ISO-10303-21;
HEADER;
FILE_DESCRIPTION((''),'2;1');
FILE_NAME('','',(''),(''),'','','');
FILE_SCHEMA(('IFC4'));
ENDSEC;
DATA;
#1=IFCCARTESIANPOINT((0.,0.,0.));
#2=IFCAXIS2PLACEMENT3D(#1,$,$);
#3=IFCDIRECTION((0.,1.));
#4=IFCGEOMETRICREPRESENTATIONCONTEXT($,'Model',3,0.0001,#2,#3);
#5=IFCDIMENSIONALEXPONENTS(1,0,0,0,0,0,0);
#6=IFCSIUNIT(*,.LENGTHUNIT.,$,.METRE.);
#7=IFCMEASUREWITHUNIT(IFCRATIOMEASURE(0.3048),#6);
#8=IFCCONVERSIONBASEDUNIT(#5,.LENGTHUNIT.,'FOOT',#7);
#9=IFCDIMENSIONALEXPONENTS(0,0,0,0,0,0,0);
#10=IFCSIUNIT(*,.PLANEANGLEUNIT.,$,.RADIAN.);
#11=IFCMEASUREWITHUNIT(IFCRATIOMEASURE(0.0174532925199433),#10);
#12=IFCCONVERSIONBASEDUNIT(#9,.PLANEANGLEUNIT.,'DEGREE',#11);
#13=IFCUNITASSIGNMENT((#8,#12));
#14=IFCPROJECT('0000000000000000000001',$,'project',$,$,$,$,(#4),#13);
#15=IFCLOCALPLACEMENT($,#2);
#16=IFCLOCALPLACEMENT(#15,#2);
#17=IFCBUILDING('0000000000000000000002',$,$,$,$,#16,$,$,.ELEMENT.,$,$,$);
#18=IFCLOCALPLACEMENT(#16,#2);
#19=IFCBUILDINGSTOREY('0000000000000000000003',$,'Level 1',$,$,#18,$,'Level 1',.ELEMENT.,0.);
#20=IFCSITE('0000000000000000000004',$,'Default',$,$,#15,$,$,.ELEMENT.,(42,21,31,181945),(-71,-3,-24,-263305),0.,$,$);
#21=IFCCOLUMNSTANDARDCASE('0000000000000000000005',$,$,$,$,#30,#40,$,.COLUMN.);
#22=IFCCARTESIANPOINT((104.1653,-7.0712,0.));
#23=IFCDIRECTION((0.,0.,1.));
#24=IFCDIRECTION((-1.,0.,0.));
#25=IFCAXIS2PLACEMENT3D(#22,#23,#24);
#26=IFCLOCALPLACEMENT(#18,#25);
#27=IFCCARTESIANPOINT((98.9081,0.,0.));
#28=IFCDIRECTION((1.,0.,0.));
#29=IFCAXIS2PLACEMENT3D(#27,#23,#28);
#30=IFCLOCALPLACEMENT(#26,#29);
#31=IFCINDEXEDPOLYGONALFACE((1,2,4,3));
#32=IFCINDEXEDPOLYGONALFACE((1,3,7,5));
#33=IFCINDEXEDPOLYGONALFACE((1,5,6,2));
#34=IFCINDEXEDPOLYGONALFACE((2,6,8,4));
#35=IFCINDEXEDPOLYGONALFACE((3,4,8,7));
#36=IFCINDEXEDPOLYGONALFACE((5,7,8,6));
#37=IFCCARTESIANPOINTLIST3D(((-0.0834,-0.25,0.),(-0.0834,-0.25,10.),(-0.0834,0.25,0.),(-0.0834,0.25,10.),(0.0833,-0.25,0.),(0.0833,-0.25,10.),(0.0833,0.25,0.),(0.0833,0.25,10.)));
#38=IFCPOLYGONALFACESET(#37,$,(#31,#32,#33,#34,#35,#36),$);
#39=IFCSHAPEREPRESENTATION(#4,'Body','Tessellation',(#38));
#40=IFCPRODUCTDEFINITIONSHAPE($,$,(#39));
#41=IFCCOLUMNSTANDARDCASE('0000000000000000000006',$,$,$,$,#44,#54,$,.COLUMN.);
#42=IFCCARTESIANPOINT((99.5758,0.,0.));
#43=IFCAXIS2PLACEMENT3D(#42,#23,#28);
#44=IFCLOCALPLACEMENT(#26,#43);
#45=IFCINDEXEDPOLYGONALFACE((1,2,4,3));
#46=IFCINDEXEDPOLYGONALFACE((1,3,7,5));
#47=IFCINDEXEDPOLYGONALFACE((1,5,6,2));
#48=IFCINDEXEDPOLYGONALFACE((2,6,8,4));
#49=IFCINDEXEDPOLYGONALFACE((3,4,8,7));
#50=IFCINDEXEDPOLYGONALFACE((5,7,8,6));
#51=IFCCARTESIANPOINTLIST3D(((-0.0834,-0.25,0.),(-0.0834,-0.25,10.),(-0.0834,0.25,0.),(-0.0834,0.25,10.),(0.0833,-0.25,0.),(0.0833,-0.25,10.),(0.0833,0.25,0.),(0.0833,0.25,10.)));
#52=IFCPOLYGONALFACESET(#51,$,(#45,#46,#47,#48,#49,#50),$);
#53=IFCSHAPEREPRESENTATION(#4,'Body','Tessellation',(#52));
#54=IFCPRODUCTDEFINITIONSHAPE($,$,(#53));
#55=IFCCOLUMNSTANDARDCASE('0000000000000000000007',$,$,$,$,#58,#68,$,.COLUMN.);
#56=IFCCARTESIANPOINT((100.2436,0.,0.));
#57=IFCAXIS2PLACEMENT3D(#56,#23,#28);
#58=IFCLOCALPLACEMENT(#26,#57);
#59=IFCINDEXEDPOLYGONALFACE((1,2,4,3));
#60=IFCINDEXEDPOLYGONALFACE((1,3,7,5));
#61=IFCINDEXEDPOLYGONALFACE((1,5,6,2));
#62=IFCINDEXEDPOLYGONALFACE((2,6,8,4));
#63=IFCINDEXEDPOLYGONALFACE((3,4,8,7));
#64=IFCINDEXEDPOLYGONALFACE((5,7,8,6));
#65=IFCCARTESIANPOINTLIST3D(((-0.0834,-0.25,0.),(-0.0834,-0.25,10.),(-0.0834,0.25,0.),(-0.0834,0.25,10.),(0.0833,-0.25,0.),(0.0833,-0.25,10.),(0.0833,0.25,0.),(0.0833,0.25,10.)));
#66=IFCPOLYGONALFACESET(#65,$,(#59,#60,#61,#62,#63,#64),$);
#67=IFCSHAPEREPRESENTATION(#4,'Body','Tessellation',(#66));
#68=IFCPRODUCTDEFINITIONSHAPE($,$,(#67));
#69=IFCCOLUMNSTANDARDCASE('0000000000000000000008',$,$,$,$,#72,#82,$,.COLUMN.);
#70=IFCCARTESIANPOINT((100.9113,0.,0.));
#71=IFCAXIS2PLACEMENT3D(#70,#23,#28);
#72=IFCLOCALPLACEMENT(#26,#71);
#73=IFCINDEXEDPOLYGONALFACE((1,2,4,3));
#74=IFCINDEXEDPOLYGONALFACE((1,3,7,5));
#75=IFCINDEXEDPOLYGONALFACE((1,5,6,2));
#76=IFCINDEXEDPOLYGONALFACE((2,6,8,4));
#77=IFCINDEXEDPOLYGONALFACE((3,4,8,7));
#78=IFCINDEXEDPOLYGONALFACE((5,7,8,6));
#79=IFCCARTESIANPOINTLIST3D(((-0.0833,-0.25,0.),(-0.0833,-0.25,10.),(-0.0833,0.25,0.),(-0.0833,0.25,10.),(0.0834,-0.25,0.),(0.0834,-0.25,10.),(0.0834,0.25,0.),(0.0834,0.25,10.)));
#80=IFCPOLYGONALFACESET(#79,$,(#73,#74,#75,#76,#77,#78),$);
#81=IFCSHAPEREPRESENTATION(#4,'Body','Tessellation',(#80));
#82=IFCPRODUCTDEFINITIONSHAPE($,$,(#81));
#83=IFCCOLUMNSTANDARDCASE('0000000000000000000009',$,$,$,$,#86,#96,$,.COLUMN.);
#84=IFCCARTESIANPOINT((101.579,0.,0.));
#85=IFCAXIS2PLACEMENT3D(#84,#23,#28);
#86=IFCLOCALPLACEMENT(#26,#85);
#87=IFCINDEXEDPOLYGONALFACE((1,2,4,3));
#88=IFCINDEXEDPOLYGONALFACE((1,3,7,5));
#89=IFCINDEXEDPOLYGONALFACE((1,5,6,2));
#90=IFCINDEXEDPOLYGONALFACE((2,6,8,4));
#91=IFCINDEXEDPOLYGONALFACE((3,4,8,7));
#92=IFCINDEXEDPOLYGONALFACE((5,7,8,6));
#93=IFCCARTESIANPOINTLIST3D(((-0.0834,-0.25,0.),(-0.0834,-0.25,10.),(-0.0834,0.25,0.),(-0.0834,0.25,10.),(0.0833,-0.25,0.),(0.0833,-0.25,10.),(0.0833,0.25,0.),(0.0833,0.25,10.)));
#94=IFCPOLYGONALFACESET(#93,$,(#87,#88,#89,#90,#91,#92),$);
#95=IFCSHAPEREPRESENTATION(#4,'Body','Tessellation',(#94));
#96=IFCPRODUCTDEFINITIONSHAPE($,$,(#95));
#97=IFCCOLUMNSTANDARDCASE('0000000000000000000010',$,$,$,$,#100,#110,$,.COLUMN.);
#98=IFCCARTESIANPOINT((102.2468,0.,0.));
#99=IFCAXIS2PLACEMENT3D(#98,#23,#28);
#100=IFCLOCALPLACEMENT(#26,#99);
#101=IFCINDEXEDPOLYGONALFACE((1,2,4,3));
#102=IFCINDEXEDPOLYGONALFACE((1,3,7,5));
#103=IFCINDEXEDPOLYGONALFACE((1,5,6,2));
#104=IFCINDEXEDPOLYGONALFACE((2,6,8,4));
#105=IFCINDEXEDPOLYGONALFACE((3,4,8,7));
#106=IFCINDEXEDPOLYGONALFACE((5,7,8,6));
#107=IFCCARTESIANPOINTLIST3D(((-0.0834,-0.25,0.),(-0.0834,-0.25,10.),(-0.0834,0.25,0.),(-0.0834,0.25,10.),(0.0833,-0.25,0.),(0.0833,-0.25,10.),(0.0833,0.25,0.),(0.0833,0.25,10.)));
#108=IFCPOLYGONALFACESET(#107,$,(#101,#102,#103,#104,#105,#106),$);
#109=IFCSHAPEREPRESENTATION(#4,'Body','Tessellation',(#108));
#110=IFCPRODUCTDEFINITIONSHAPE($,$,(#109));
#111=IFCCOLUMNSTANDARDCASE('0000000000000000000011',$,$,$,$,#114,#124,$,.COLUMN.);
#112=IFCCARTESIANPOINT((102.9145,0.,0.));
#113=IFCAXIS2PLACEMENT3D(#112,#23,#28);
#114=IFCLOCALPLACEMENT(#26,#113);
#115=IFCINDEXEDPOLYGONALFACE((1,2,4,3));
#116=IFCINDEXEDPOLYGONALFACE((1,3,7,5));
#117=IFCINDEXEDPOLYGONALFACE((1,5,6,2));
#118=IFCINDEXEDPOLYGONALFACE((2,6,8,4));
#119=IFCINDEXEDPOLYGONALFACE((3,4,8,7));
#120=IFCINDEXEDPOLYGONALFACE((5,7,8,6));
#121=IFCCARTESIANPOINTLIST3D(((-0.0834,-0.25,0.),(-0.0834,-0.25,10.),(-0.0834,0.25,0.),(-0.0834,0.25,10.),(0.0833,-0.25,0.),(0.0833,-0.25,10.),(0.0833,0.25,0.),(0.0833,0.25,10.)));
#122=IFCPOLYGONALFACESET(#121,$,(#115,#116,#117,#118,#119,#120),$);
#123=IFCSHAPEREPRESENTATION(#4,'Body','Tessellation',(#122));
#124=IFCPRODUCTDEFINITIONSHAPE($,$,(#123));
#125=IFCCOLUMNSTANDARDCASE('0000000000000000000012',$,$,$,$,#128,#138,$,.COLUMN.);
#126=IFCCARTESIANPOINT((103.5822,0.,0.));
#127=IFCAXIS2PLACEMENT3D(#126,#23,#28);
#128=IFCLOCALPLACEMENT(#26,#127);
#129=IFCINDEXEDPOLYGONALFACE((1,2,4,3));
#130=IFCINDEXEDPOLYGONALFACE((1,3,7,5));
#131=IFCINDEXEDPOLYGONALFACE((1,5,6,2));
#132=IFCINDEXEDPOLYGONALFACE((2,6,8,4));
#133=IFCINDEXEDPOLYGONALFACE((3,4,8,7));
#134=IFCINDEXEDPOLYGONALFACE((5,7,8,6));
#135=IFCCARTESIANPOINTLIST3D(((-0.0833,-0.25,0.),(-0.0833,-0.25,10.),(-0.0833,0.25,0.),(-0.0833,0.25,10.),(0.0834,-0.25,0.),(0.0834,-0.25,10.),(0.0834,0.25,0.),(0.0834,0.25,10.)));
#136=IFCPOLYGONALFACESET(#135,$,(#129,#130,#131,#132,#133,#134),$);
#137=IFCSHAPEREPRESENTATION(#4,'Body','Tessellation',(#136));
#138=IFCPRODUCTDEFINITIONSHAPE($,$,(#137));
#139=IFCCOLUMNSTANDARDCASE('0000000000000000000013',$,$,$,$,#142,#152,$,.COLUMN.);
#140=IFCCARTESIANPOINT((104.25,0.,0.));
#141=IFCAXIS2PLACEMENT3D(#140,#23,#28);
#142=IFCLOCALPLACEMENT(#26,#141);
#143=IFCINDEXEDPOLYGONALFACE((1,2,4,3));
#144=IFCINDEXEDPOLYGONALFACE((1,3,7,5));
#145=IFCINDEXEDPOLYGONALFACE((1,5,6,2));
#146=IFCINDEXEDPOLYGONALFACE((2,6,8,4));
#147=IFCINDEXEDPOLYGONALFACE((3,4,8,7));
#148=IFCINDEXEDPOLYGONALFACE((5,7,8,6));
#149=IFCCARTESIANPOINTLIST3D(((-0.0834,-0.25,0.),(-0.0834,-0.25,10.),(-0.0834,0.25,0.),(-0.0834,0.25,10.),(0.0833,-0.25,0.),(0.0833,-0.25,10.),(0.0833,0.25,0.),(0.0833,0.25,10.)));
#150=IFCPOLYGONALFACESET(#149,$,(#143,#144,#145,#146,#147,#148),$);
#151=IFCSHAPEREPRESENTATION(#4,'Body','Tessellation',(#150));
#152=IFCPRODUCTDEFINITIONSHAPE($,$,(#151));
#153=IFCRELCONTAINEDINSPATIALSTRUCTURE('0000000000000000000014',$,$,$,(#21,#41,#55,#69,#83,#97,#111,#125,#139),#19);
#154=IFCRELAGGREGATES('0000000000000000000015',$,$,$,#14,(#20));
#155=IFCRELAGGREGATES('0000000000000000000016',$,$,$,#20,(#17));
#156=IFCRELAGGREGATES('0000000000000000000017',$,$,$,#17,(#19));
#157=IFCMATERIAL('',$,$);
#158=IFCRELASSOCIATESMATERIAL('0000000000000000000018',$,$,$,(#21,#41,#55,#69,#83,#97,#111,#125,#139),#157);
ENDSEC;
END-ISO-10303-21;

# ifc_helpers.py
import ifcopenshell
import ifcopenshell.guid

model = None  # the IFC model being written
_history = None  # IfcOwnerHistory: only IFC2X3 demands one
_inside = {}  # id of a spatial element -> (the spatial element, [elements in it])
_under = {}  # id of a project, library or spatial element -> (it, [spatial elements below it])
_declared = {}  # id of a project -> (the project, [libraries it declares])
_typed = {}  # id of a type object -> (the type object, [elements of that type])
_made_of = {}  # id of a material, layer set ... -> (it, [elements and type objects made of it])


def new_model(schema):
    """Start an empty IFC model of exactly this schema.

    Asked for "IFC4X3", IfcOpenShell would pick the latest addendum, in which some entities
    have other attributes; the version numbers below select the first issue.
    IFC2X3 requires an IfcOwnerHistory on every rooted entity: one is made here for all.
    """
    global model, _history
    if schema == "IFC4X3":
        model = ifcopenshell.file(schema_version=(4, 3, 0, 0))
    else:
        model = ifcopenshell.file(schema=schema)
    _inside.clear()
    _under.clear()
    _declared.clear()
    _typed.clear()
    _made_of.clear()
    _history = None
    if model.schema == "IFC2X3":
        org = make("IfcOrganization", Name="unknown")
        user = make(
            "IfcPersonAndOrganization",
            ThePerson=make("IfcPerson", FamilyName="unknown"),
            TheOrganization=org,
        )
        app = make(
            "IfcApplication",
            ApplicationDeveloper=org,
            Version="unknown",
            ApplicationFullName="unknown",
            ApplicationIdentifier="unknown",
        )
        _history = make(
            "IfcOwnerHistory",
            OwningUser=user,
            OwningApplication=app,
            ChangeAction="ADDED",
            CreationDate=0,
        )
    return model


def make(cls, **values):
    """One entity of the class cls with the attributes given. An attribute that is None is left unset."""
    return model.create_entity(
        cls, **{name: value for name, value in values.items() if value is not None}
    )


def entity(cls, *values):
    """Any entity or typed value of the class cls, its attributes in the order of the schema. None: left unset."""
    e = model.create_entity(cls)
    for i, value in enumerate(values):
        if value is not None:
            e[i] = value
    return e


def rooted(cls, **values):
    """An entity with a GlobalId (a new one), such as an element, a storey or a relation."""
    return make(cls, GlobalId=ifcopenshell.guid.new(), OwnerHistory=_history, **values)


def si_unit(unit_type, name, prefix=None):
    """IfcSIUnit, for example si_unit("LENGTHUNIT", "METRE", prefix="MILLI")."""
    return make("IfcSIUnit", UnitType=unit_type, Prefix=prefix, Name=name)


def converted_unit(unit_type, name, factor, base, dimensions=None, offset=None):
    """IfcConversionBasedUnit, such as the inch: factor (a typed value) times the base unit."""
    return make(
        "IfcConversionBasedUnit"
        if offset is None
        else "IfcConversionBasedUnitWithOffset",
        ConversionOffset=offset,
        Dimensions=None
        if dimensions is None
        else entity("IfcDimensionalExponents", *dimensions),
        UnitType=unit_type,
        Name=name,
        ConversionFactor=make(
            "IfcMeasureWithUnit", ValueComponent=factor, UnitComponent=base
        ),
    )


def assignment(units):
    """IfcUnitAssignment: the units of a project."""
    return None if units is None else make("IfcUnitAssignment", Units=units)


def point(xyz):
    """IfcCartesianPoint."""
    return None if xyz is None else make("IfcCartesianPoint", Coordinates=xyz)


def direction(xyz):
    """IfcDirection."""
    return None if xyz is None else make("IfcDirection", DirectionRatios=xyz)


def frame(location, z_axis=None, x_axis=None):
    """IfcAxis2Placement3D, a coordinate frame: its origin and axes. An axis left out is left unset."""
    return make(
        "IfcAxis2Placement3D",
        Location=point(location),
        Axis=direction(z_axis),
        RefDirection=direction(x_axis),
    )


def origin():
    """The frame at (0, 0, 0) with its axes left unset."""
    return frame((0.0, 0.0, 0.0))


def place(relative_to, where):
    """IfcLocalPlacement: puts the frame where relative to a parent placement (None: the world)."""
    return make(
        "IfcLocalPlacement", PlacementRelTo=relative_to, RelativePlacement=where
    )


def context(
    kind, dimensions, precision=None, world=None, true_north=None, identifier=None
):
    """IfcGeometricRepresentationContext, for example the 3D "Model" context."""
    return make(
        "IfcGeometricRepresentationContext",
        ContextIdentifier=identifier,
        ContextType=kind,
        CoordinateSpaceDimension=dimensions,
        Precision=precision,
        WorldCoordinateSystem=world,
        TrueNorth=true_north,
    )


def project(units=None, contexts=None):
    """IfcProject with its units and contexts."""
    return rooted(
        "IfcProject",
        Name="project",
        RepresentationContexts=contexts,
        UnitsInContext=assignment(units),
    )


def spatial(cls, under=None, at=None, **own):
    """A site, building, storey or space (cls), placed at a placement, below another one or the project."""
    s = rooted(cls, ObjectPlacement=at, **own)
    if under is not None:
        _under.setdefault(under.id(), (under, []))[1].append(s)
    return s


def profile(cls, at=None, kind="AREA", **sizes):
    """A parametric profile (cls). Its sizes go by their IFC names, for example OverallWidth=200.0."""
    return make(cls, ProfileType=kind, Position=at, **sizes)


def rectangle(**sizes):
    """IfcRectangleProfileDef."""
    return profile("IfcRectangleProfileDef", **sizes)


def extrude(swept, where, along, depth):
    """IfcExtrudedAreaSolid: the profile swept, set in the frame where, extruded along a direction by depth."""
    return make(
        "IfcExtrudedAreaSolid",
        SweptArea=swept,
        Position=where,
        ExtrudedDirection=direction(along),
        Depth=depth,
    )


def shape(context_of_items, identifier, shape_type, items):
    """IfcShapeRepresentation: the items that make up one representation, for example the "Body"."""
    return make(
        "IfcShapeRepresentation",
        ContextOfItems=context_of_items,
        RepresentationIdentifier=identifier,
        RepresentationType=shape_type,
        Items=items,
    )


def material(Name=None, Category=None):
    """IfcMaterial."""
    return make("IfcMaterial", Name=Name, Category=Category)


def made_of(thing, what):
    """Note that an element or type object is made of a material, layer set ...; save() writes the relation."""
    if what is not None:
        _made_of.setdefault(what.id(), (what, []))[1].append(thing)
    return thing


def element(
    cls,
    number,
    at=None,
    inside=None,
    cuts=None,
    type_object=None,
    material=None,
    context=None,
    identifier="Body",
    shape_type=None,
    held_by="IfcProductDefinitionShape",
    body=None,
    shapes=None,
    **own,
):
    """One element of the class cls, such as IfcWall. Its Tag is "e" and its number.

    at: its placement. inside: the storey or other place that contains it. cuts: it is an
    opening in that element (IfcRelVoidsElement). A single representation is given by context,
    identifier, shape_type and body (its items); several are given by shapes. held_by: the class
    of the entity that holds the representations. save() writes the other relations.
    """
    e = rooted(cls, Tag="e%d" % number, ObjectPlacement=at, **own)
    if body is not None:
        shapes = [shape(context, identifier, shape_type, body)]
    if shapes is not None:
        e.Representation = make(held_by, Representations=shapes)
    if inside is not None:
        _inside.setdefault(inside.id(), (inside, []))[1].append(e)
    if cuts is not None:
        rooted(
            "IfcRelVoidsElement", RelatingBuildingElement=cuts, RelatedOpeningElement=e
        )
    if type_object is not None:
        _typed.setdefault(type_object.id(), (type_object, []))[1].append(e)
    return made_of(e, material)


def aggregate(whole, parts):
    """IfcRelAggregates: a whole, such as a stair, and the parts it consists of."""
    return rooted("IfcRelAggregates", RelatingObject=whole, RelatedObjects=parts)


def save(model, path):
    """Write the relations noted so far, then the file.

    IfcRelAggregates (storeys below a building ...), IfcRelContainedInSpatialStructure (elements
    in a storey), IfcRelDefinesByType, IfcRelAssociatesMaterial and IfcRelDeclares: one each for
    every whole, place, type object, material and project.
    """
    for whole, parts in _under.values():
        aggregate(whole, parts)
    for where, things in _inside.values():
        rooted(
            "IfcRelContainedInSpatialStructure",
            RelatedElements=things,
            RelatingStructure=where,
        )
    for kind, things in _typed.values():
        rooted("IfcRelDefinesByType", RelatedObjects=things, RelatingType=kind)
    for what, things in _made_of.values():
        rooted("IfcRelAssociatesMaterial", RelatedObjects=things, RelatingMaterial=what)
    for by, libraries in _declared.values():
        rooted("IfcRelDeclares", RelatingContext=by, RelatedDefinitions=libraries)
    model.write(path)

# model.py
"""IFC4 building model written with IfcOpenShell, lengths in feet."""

from ifc_helpers import new_model, entity, si_unit, converted_unit, direction, frame, origin, place, context, project, spatial, rectangle, extrude, material, element, save


model = new_model("IFC4")

# Units and contexts
model_context = context("Model", 3, precision=0.0001, world=origin(), true_north=direction((0.0, 1.0)))
ifc_project = project(units=[converted_unit("LENGTHUNIT", "FOOT", entity("IfcRatioMeasure", 0.3048), si_unit("LENGTHUNIT", "METRE"), dimensions=[1, 0, 0, 0, 0, 0, 0]), converted_unit("PLANEANGLEUNIT", "DEGREE", entity("IfcRatioMeasure", 0.0174532925199433), si_unit("PLANEANGLEUNIT", "RADIAN"), dimensions=[0, 0, 0, 0, 0, 0, 0])], contexts=[model_context])

# Site, building, storey
site_placement = place(None, origin())
site = spatial("IfcSite", under=ifc_project, at=site_placement, Name="Default", CompositionType="ELEMENT", RefLatitude=(42, 21, 31, 181945), RefLongitude=(-71, -3, -24, -263305), RefElevation=0.0)
building_placement = place(site_placement, origin())
building = spatial("IfcBuilding", under=site, at=building_placement, CompositionType="ELEMENT")
storey_placement = place(building_placement, origin())
storey = spatial("IfcBuildingStorey", under=building, at=storey_placement, Name="Level 1", LongName="Level 1", CompositionType="ELEMENT", Elevation=0.0)

# Columns
ifc_material = material(Name="")
placement = place(storey_placement, frame((104.1653, -7.0712, 0.0), z_axis=(0.0, 0.0, 1.0), x_axis=(-1.0, 0.0, 0.0)))
for number, where, z_axis, x_axis in (
    (1, (98.9081, 0.0, 0.0), (0.0, 0.0, 1.0), (1.0, 0.0, 0.0)),
    (2, (99.5758, 0.0, 0.0), (0.0, 0.0, 1.0), (1.0, 0.0, 0.0)),
    (3, (100.2436, 0.0, 0.0), (0.0, 0.0, 1.0), (1.0, 0.0, 0.0)),
    (4, (100.9113, 0.0, 0.0), (0.0, 0.0, 1.0), (1.0, 0.0, 0.0)),
    (5, (101.579, 0.0, 0.0), (0.0, 0.0, 1.0), (1.0, 0.0, 0.0)),
    (6, (102.2468, 0.0, 0.0), (0.0, 0.0, 1.0), (1.0, 0.0, 0.0)),
    (7, (102.9145, 0.0, 0.0), (0.0, 0.0, 1.0), (1.0, 0.0, 0.0)),
    (8, (103.5822, 0.0, 0.0), (0.0, 0.0, 1.0), (1.0, 0.0, 0.0)),
    (9, (104.25, 0.0, 0.0), (0.0, 0.0, 1.0), (1.0, 0.0, 0.0)),
):
    element("IfcColumnStandardCase", number, at=place(placement, frame(where, z_axis=z_axis, x_axis=x_axis)), inside=storey, material=ifc_material, PredefinedType="COLUMN", context=model_context, shape_type="SweptSolid", body=[
        extrude(rectangle(XDim=0.1667, YDim=0.5), origin(), (0.0, 0.0, 1.0), 10.0),
    ])

save(model, "model.ifc")
